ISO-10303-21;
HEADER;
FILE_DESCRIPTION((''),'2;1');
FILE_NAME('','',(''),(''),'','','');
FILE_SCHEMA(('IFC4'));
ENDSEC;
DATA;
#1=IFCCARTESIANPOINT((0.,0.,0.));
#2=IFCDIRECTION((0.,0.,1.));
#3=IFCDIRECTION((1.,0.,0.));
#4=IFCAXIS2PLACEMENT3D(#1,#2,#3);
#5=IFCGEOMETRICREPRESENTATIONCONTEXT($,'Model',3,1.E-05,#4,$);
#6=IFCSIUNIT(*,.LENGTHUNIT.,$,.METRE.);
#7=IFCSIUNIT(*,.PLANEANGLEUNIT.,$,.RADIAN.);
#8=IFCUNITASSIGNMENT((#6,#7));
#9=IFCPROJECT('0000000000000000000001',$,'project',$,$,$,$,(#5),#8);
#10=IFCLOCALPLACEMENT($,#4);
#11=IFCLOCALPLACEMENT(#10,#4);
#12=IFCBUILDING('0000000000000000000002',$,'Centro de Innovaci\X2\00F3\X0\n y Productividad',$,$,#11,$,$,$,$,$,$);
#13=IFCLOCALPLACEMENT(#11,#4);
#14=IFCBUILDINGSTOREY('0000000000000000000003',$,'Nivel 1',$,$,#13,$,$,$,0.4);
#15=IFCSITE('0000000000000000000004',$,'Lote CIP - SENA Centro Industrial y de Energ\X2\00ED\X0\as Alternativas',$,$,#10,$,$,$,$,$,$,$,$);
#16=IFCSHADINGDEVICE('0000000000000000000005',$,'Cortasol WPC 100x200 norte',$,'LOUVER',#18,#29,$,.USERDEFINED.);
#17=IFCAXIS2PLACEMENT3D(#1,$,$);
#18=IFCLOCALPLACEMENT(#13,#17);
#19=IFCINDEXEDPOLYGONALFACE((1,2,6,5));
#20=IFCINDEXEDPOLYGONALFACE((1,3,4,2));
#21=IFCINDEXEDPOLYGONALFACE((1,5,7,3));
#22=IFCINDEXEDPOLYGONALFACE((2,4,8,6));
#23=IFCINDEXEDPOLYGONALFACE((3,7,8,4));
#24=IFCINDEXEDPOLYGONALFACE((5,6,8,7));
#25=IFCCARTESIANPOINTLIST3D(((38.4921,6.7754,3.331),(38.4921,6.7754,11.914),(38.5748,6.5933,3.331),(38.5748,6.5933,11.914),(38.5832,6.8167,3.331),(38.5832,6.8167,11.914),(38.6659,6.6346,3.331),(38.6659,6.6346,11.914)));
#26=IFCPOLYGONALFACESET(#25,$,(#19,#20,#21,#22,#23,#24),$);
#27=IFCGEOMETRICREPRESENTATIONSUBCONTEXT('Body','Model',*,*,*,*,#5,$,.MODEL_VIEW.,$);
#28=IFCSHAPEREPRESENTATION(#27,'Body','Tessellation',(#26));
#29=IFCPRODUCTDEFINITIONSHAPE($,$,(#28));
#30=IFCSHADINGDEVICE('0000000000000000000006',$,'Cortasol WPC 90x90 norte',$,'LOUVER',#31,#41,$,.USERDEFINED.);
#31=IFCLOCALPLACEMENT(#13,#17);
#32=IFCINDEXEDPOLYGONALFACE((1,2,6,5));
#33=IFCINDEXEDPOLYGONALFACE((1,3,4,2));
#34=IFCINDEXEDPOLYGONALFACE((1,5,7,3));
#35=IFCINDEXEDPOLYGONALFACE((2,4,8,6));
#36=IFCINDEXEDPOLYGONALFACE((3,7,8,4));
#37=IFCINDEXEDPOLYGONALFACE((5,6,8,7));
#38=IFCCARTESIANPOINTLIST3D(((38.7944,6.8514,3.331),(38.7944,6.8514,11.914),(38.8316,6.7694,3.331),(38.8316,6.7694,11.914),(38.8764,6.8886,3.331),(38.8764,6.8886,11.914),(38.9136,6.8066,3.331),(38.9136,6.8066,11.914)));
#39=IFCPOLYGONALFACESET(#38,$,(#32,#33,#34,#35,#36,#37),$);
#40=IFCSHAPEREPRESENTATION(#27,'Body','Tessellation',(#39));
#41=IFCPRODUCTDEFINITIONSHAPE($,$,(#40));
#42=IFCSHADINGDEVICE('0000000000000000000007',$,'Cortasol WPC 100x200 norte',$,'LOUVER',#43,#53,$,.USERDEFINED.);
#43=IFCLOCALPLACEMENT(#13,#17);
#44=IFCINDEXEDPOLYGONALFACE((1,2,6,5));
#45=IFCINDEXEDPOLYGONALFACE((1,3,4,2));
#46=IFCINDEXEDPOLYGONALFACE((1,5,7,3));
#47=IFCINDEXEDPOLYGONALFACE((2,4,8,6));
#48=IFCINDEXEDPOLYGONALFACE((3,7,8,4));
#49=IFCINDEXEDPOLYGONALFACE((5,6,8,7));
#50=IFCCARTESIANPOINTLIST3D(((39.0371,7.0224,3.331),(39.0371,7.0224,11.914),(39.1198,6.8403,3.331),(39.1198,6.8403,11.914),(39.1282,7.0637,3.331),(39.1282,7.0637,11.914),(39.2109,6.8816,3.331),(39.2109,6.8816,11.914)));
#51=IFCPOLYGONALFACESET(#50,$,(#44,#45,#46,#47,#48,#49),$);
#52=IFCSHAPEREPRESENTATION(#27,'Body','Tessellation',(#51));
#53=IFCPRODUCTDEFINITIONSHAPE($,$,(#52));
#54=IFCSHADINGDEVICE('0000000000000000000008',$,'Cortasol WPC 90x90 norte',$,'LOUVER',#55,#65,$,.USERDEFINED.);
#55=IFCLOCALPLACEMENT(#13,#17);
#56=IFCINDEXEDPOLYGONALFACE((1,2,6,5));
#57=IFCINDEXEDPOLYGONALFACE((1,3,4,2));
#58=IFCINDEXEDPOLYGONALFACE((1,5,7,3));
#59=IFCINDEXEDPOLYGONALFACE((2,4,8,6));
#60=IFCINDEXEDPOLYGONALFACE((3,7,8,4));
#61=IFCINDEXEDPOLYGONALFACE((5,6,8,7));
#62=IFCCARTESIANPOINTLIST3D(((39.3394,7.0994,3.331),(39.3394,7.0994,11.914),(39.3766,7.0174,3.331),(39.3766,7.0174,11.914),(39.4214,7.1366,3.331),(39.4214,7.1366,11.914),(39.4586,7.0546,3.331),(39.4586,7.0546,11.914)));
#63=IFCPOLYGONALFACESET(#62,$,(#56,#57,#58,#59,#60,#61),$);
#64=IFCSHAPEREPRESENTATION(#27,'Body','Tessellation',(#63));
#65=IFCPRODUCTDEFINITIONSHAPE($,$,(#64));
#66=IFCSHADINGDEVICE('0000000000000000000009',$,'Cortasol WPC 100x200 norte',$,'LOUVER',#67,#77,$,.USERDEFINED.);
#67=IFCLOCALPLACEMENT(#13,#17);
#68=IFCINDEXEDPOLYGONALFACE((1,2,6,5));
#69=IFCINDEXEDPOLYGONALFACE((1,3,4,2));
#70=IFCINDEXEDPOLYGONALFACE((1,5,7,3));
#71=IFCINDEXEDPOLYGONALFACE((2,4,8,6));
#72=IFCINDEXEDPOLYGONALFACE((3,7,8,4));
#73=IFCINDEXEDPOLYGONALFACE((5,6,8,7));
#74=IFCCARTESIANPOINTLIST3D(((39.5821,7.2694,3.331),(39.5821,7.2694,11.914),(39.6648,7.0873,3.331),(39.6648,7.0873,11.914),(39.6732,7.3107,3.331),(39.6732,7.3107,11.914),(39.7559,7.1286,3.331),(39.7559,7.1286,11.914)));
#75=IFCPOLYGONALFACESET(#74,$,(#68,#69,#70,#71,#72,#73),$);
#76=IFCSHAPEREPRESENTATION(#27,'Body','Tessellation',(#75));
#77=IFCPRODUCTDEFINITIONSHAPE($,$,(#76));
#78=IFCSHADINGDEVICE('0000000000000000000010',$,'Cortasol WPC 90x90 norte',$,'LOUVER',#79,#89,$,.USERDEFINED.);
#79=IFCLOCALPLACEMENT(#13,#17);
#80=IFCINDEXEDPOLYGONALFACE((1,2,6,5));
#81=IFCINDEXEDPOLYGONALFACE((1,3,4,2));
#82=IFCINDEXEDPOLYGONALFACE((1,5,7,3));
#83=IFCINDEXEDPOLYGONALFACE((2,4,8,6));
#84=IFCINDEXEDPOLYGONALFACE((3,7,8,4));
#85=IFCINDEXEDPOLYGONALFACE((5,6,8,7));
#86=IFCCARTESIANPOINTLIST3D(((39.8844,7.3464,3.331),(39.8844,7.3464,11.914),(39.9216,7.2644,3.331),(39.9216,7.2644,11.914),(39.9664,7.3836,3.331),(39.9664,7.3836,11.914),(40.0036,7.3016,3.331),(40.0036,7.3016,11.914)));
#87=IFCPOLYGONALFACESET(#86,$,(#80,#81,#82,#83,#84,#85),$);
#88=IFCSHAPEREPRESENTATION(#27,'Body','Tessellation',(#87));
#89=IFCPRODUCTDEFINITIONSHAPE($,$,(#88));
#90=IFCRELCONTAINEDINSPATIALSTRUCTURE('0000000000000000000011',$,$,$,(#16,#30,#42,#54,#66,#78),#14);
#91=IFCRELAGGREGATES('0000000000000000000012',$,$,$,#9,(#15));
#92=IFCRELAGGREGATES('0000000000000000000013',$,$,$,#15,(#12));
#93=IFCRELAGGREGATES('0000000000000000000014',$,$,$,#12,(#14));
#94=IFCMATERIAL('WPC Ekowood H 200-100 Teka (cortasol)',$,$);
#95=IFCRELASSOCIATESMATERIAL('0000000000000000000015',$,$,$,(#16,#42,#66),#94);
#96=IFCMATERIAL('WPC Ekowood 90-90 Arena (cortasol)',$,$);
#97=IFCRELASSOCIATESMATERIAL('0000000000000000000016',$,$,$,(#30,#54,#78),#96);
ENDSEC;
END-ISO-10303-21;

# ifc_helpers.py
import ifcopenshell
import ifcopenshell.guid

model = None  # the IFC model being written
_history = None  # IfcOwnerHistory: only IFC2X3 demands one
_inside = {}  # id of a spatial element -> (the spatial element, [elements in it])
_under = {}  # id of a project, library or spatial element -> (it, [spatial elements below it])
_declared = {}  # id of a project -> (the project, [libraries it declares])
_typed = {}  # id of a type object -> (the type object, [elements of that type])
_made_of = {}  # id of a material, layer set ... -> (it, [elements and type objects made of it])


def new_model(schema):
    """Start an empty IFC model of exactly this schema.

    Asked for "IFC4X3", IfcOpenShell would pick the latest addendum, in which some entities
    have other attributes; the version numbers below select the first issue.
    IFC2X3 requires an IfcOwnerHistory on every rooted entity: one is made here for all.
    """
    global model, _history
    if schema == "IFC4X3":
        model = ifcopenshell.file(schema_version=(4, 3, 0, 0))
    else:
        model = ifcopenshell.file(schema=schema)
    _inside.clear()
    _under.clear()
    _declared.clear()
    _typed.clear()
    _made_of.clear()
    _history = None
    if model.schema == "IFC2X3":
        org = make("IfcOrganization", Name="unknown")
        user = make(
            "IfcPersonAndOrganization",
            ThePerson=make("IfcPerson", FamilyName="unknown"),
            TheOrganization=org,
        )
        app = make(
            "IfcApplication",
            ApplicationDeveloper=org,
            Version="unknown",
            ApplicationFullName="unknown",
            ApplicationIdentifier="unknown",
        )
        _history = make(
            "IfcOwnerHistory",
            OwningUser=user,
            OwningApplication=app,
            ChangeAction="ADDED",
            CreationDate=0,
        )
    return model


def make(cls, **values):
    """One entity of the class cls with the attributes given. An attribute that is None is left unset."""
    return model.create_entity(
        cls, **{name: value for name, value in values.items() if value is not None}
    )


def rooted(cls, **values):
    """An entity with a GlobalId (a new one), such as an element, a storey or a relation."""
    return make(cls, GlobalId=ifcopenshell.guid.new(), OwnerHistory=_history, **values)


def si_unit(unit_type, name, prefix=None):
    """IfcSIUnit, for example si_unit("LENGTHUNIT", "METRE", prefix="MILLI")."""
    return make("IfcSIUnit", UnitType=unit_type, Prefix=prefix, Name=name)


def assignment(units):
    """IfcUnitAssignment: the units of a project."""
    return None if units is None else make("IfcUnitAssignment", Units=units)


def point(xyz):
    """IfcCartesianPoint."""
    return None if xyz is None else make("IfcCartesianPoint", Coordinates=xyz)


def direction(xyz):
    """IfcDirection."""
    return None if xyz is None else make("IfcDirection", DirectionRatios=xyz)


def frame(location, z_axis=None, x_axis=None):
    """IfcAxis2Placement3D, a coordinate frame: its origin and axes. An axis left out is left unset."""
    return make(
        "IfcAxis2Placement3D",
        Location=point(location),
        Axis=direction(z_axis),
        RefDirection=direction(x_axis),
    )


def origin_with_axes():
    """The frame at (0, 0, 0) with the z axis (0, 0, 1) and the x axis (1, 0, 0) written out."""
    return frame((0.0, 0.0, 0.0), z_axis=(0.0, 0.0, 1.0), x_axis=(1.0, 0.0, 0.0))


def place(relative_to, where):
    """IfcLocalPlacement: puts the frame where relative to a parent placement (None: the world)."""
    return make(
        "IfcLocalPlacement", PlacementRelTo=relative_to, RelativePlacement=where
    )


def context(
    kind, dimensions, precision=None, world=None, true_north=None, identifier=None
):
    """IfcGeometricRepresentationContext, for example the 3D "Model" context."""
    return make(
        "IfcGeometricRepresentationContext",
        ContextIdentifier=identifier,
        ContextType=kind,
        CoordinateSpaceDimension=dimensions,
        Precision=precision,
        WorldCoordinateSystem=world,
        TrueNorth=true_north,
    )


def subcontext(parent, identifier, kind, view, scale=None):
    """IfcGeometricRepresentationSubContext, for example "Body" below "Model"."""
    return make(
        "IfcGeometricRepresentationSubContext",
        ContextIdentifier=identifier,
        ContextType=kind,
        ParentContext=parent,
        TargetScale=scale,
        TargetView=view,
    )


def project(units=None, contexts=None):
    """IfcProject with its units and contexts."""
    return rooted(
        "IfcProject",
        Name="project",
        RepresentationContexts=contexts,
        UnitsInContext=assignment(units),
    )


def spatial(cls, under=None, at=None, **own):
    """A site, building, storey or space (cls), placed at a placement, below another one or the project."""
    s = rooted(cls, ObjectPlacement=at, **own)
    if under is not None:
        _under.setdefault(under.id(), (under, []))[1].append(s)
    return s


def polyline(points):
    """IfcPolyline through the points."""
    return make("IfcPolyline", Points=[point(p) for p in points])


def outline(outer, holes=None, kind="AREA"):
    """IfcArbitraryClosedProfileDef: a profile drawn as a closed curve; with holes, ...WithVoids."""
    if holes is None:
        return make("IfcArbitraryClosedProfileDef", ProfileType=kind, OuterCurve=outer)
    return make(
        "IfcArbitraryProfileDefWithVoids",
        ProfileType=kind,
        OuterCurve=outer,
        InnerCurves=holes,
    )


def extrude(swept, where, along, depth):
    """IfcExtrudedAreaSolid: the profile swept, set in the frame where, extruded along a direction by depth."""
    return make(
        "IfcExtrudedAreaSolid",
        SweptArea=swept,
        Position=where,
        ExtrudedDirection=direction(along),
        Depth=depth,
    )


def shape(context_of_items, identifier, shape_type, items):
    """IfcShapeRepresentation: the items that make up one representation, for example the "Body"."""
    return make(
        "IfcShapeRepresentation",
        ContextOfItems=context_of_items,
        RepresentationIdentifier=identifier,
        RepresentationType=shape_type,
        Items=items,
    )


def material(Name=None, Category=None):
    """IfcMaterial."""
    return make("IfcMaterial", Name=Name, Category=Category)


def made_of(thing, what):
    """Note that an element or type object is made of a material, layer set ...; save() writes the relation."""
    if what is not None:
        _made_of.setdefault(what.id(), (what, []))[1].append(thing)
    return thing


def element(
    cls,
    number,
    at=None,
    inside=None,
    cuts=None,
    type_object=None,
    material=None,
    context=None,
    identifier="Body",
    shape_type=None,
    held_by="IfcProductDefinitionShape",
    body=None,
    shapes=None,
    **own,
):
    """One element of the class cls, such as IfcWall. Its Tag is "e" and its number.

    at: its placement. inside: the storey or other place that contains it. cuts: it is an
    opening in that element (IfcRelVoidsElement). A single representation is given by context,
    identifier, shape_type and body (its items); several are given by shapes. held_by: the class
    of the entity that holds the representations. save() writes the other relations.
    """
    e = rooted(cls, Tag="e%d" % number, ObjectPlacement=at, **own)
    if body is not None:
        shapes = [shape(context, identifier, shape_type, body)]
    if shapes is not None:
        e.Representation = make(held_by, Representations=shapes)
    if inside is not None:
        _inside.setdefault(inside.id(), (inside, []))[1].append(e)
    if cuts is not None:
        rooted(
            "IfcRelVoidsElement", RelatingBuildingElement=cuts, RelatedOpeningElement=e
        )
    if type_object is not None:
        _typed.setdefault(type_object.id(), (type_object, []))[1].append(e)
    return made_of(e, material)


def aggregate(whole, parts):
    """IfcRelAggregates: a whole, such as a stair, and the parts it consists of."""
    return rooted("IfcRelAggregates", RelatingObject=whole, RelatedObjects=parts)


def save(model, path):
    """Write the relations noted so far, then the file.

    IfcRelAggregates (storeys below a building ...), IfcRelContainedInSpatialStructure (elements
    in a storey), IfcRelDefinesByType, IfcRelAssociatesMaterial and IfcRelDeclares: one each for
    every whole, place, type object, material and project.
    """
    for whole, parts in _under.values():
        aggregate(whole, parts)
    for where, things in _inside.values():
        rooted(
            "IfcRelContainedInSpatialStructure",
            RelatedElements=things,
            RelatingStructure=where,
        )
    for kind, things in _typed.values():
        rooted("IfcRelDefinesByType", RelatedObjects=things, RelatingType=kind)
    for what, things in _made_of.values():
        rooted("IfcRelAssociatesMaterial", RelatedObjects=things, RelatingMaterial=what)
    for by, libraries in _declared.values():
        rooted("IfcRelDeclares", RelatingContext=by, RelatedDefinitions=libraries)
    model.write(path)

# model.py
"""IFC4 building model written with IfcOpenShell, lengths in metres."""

from ifc_helpers import new_model, si_unit, frame, origin_with_axes, place, context, subcontext, project, spatial, polyline, outline, extrude, material, element, save


model = new_model("IFC4")

# Units and contexts
model_context = context("Model", 3, precision=1e-05, world=origin_with_axes())
body_context = subcontext(model_context, "Body", "Model", "MODEL_VIEW")
ifc_project = project(units=[si_unit("LENGTHUNIT", "METRE"), si_unit("PLANEANGLEUNIT", "RADIAN")], contexts=[model_context])

# Site, building, storey
site_placement = place(None, origin_with_axes())
site = spatial("IfcSite", under=ifc_project, at=site_placement, Name="Lote CIP - SENA Centro Industrial y de Energías Alternativas")
building_placement = place(site_placement, origin_with_axes())
building = spatial("IfcBuilding", under=site, at=building_placement, Name="Centro de Innovación y Productividad")
storey_placement = place(building_placement, origin_with_axes())
storey = spatial("IfcBuildingStorey", under=building, at=storey_placement, Name="Nivel 1", Elevation=0.4)

# Shading devices
ifc_material_1 = material(Name="WPC Ekowood 90-90 Arena (cortasol)")
ifc_material_2 = material(Name="WPC Ekowood H 200-100 Teka (cortasol)")
shading_device_1_placement = place(storey_placement, origin_with_axes())
element("IfcShadingDevice", 1, at=shading_device_1_placement, inside=storey, material=ifc_material_2, Name="Cortasol WPC 100x200 norte", ObjectType="LOUVER", PredefinedType="USERDEFINED", context=body_context, shape_type="SweptSolid", body=[
    extrude(outline(polyline([(38.5748, 6.5933), (38.4921, 6.7754), (38.5832, 6.8167), (38.6659, 6.6346), (38.5748, 6.5933)])), frame((0.0, 0.0, 3.331)), (0.0, 0.0, 1.0), 8.583),
])
shading_device_2_placement = place(storey_placement, origin_with_axes())
element("IfcShadingDevice", 2, at=shading_device_2_placement, inside=storey, material=ifc_material_1, Name="Cortasol WPC 90x90 norte", ObjectType="LOUVER", PredefinedType="USERDEFINED", context=body_context, shape_type="SweptSolid", body=[
    extrude(outline(polyline([(38.8316, 6.7694), (38.7944, 6.8514), (38.8764, 6.8886), (38.9136, 6.8066), (38.8316, 6.7694)])), frame((0.0, 0.0, 3.331)), (0.0, 0.0, 1.0), 8.583),
])
shading_device_3_placement = place(storey_placement, origin_with_axes())
element("IfcShadingDevice", 3, at=shading_device_3_placement, inside=storey, material=ifc_material_2, Name="Cortasol WPC 100x200 norte", ObjectType="LOUVER", PredefinedType="USERDEFINED", context=body_context, shape_type="SweptSolid", body=[
    extrude(outline(polyline([(39.1198, 6.8403), (39.0371, 7.0224), (39.1282, 7.0637), (39.2109, 6.8816), (39.1198, 6.8403)])), frame((0.0, 0.0, 3.331)), (0.0, 0.0, 1.0), 8.583),
])
shading_device_4_placement = place(storey_placement, origin_with_axes())
element("IfcShadingDevice", 4, at=shading_device_4_placement, inside=storey, material=ifc_material_1, Name="Cortasol WPC 90x90 norte", ObjectType="LOUVER", PredefinedType="USERDEFINED", context=body_context, shape_type="SweptSolid", body=[
    extrude(outline(polyline([(39.3766, 7.0174), (39.3394, 7.0994), (39.4214, 7.1366), (39.4586, 7.0546), (39.3766, 7.0174)])), frame((0.0, 0.0, 3.331)), (0.0, 0.0, 1.0), 8.583),
])
shading_device_5_placement = place(storey_placement, origin_with_axes())
element("IfcShadingDevice", 5, at=shading_device_5_placement, inside=storey, material=ifc_material_2, Name="Cortasol WPC 100x200 norte", ObjectType="LOUVER", PredefinedType="USERDEFINED", context=body_context, shape_type="SweptSolid", body=[
    extrude(outline(polyline([(39.6648, 7.0873), (39.5821, 7.2694), (39.6732, 7.3107), (39.7559, 7.1286), (39.6648, 7.0873)])), frame((0.0, 0.0, 3.331)), (0.0, 0.0, 1.0), 8.583),
])
shading_device_6_placement = place(storey_placement, origin_with_axes())
element("IfcShadingDevice", 6, at=shading_device_6_placement, inside=storey, material=ifc_material_1, Name="Cortasol WPC 90x90 norte", ObjectType="LOUVER", PredefinedType="USERDEFINED", context=body_context, shape_type="SweptSolid", body=[
    extrude(outline(polyline([(39.9216, 7.2644), (39.8844, 7.3464), (39.9664, 7.3836), (40.0036, 7.3016), (39.9216, 7.2644)])), frame((0.0, 0.0, 3.331)), (0.0, 0.0, 1.0), 8.583),
])

save(model, "model.ifc")
